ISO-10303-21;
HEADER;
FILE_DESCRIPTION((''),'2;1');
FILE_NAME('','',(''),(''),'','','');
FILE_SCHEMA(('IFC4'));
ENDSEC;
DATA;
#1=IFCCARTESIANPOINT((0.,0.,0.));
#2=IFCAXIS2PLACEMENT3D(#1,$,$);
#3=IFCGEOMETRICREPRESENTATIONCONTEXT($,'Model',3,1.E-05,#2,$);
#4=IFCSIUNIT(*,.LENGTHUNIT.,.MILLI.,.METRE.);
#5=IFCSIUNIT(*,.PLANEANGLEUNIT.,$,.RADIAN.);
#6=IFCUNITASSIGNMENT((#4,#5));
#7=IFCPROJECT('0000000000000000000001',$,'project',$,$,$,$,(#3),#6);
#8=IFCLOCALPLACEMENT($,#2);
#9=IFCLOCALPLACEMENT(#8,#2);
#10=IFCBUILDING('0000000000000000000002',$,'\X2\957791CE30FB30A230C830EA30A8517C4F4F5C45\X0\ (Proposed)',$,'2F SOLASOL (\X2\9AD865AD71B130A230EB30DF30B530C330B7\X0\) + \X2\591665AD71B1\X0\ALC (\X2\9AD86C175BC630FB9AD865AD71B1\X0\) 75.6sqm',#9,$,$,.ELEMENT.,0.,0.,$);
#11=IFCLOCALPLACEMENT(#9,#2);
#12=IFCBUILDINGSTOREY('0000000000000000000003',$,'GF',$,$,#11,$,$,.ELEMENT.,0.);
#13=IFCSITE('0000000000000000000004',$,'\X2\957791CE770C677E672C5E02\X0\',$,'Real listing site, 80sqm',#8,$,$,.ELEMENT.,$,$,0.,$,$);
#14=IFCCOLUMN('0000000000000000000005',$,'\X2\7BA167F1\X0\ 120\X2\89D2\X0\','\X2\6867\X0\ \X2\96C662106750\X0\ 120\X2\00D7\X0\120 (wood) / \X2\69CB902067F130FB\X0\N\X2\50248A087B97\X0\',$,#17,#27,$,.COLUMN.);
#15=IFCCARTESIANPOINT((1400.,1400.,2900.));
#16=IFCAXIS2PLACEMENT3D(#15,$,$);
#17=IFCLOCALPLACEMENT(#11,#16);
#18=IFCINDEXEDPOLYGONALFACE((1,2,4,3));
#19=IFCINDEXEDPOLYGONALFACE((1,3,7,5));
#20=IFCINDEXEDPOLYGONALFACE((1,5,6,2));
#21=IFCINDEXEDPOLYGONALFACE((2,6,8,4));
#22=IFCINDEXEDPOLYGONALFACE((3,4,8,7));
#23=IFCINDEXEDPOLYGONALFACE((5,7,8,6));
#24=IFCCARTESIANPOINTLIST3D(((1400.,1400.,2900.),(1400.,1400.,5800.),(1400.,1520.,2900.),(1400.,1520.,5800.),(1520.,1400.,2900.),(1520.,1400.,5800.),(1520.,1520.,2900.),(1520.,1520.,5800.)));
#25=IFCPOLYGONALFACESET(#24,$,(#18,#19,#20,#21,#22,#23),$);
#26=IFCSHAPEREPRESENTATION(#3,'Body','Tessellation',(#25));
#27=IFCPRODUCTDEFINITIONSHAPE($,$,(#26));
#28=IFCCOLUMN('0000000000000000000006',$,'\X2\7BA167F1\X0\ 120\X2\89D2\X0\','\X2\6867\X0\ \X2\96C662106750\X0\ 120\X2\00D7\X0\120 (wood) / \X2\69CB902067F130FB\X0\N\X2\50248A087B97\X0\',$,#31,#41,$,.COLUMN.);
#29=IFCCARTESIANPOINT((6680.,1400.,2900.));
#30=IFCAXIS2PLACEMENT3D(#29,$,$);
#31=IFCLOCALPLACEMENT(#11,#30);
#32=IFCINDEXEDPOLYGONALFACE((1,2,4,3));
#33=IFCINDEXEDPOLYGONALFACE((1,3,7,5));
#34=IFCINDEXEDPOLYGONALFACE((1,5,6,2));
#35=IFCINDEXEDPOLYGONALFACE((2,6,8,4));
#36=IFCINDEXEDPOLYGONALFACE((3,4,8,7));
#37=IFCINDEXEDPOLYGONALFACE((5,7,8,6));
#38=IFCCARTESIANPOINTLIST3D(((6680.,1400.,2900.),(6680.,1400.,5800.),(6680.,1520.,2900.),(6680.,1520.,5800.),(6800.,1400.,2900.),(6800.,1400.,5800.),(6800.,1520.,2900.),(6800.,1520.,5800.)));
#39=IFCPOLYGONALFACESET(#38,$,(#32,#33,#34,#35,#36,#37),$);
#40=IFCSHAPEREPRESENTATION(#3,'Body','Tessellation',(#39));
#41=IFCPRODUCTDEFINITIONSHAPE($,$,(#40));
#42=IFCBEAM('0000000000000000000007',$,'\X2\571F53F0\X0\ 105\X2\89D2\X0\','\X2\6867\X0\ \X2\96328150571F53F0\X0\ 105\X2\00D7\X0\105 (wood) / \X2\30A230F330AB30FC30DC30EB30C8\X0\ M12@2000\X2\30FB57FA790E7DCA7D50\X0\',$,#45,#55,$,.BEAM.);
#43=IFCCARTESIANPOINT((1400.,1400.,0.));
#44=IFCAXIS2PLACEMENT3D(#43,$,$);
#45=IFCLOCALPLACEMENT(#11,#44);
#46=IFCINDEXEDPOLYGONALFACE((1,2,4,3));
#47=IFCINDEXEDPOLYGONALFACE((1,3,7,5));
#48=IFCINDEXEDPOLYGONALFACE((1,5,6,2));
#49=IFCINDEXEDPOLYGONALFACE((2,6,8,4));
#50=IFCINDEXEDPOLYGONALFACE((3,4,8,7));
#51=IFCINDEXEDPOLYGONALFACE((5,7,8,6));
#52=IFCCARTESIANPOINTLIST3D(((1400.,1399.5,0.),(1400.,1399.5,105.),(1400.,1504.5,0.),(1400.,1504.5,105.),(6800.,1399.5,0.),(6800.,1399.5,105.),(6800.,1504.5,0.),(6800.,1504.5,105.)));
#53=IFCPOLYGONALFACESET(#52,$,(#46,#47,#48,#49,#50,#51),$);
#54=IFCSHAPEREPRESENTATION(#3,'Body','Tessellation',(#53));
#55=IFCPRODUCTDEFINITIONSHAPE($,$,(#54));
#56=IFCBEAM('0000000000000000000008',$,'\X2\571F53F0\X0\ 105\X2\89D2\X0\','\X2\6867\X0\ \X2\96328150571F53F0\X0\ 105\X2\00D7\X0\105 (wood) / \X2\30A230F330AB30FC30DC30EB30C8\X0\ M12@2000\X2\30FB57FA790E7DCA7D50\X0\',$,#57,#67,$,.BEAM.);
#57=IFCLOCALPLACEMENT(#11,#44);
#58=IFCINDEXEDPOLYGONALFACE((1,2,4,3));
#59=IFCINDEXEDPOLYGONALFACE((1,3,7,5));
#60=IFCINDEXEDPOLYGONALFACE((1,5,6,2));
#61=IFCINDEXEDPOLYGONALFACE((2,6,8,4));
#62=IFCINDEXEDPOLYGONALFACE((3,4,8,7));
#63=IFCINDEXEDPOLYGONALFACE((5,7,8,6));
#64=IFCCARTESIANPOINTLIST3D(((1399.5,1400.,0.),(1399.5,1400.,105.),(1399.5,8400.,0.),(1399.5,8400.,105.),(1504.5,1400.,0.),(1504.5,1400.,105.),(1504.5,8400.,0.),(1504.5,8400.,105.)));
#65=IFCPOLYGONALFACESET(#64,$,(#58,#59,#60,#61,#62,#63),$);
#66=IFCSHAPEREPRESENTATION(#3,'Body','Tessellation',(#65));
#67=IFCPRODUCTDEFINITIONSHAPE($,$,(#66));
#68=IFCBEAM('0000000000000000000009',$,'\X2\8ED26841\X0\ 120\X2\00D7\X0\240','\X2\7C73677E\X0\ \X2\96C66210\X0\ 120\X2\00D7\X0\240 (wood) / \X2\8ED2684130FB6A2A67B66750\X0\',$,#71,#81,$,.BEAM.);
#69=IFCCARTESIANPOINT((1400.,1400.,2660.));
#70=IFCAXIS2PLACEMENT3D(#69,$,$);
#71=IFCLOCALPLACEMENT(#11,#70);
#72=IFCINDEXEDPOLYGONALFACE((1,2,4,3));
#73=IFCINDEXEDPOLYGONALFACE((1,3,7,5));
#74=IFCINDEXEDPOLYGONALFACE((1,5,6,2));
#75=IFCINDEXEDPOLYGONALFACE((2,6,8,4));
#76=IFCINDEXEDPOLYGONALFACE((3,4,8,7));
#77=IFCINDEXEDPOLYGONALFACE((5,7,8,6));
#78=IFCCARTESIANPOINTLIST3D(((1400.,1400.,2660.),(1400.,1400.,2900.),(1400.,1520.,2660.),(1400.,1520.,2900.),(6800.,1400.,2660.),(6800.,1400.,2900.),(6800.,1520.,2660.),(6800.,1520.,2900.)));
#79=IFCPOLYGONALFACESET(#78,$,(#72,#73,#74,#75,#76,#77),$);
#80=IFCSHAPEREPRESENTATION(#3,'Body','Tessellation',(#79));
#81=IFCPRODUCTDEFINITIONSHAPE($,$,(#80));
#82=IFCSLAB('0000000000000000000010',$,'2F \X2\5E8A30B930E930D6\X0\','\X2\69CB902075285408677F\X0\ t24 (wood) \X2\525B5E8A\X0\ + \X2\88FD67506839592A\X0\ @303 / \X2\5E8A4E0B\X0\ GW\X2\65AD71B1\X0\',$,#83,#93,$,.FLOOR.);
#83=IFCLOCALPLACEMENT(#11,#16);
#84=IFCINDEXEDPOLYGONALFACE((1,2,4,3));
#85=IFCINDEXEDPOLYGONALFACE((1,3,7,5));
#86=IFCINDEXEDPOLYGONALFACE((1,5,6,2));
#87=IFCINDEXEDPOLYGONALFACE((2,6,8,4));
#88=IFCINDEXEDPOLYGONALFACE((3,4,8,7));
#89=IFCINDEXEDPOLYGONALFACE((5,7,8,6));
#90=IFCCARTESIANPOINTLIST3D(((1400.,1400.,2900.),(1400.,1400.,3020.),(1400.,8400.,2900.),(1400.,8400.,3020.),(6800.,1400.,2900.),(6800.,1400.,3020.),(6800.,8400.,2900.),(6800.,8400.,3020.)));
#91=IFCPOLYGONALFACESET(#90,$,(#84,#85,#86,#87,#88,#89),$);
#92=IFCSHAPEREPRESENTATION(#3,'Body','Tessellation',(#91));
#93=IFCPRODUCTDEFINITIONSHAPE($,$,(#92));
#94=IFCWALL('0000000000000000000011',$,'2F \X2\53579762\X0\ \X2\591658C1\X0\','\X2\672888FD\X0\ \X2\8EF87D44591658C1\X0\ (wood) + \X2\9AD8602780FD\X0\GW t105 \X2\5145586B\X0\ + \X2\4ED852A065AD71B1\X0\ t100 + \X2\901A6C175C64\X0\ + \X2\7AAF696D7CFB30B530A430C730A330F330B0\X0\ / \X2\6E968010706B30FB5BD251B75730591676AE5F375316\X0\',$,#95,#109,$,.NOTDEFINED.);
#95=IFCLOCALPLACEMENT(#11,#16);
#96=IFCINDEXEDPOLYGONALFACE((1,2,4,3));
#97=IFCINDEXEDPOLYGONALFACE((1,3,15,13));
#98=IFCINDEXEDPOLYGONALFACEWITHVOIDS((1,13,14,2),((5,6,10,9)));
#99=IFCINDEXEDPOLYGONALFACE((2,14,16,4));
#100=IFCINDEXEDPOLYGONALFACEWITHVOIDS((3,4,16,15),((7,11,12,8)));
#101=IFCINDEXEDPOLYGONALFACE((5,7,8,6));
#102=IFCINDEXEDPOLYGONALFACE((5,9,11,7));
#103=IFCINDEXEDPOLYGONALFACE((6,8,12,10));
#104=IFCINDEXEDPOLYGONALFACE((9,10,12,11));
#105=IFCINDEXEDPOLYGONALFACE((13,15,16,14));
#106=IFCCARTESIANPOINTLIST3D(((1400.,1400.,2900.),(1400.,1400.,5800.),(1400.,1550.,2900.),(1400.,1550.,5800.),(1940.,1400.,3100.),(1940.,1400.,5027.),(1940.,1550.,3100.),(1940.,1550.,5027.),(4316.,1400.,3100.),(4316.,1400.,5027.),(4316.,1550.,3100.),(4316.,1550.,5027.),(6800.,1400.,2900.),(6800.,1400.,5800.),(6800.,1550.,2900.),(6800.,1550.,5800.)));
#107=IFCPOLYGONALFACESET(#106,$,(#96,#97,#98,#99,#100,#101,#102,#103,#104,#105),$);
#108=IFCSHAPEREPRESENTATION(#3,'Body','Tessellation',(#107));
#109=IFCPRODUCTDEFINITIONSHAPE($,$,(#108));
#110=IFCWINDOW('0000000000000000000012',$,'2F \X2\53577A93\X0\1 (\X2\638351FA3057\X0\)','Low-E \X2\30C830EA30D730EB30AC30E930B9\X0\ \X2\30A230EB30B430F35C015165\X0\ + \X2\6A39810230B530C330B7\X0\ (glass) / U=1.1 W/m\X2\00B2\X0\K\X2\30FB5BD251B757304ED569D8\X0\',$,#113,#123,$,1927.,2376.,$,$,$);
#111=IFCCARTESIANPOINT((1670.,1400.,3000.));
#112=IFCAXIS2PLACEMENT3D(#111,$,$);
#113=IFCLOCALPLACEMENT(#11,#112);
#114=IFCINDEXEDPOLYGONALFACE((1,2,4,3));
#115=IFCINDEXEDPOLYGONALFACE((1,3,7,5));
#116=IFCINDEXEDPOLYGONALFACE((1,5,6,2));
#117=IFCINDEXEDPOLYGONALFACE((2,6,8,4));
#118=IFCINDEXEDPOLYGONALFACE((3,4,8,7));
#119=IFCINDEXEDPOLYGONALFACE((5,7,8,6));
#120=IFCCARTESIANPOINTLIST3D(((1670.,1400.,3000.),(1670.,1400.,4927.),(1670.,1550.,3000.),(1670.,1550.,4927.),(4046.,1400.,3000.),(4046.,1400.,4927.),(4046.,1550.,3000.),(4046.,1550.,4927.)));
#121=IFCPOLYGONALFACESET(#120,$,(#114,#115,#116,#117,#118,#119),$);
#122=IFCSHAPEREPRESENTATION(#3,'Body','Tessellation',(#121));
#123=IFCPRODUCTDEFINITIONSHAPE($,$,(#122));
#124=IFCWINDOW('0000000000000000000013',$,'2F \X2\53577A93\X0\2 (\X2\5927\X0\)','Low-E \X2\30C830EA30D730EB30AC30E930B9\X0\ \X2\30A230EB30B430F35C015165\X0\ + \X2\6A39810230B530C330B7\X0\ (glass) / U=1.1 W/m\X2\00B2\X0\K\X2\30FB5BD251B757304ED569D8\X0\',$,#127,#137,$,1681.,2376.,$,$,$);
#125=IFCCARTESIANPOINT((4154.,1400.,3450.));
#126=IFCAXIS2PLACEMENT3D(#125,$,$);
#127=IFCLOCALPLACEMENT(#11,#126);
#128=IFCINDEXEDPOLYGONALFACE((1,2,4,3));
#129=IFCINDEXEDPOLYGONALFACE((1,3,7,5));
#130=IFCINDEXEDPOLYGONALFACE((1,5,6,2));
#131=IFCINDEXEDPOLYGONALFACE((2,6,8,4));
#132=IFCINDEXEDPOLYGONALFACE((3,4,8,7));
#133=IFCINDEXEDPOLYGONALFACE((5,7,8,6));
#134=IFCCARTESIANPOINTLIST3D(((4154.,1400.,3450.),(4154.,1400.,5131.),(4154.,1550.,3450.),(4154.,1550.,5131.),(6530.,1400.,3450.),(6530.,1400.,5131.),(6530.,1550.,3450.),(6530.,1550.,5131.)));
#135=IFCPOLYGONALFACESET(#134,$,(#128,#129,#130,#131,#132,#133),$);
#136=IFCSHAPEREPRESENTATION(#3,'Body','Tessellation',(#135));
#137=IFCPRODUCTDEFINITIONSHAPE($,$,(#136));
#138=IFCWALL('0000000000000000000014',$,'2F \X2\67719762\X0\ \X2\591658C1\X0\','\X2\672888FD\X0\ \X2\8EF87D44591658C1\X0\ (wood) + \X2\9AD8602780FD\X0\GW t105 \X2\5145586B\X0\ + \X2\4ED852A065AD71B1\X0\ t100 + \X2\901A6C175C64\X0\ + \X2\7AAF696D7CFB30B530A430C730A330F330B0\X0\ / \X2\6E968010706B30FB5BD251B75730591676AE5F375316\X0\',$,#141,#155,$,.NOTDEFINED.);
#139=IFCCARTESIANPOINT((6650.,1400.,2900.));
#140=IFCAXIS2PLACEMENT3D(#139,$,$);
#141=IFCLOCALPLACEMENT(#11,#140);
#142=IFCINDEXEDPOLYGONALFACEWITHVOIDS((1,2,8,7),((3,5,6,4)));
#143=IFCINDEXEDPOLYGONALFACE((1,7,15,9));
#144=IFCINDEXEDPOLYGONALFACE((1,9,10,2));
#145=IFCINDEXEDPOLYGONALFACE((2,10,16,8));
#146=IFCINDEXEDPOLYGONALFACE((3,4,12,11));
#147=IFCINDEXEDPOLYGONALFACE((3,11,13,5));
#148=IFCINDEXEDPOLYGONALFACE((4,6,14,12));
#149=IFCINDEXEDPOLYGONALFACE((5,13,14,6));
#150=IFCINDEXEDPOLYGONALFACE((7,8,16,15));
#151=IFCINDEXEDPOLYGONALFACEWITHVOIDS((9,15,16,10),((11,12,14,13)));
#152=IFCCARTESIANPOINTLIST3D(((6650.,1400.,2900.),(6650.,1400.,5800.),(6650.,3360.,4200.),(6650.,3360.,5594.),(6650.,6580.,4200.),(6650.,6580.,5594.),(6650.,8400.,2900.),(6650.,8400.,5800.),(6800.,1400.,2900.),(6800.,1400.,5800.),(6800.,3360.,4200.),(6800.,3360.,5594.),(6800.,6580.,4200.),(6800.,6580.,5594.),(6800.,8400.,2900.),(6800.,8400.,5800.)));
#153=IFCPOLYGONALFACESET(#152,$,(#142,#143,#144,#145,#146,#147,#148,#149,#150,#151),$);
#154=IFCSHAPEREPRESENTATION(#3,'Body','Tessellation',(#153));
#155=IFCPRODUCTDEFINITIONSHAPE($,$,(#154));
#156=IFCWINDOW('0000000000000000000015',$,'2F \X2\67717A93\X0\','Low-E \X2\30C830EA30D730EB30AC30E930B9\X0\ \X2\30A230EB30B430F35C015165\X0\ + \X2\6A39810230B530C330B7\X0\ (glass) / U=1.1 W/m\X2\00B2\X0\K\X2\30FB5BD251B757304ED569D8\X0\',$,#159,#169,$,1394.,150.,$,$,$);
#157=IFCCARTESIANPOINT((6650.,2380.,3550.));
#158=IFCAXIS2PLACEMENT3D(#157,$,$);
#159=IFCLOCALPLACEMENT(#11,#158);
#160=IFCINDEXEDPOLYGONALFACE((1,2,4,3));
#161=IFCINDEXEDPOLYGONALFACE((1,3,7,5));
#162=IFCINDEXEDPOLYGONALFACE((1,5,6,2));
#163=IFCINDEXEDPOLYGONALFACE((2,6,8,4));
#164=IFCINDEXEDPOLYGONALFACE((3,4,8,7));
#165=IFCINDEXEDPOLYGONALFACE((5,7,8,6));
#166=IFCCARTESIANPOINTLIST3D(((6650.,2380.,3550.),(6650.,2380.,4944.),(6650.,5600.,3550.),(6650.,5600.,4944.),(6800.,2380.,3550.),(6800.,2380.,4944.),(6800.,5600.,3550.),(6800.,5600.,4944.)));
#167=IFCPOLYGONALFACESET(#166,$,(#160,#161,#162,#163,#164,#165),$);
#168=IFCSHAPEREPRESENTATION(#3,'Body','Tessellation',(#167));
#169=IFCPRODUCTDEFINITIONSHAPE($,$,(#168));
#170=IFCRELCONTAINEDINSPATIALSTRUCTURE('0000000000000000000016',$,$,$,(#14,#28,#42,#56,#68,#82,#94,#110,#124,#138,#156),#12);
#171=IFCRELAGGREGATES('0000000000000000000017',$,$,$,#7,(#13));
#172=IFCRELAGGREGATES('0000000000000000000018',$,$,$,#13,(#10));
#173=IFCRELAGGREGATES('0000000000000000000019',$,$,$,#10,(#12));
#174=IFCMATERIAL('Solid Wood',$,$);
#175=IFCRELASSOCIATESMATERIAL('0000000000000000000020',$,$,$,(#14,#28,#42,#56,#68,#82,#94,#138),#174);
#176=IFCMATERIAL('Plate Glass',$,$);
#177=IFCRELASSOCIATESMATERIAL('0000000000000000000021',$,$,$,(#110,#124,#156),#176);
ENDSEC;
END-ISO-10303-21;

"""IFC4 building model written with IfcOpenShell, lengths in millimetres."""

from ifc_helpers import new_model, si_unit, frame, frame_2d, origin, place, context, project, spatial, rectangle, extrude, material, element, fill, save


model = new_model("IFC4")

# Units and contexts
model_context = context("Model", 3, precision=1e-05, world=origin())
ifc_project = project(units=[si_unit("LENGTHUNIT", "METRE", prefix="MILLI"), si_unit("PLANEANGLEUNIT", "RADIAN")], contexts=[model_context])

# Site, building, storey
site_placement = place(None, origin())
site = spatial("IfcSite", under=ifc_project, at=site_placement, Name="長野県松本市", ObjectType="Real listing site, 80sqm", CompositionType="ELEMENT", RefElevation=0.0)
building_placement = place(site_placement, origin())
building = spatial("IfcBuilding", under=site, at=building_placement, Name="長野・アトリエ兼住居 (Proposed)", ObjectType="2F SOLASOL (高断熱アルミサッシ) + 外断熱ALC (高気密・高断熱) 75.6sqm", CompositionType="ELEMENT", ElevationOfRefHeight=0.0, ElevationOfTerrain=0.0)
storey_placement = place(building_placement, origin())
storey = spatial("IfcBuildingStorey", under=building, at=storey_placement, Name="GF", CompositionType="ELEMENT", Elevation=0.0)

# Columns
ifc_material_1 = material(Name="Solid Wood")
column_1_placement = place(storey_placement, frame((1400.0, 1400.0, 2900.0)))
element("IfcColumn", 1, at=column_1_placement, inside=storey, material=ifc_material_1, Name="管柱 120角", Description="桧 集成材 120×120 (wood) / 構造柱・N値計算", PredefinedType="COLUMN", context=model_context, shape_type="SweptSolid", body=[
    extrude(rectangle(XDim=120.0, YDim=120.0, at=frame_2d((60.0, 60.0))), frame((1400.0, 1400.0, 2900.0)), (0.0, 0.0, 1.0), 2900.0),
])
column_2_placement = place(storey_placement, frame((6680.0, 1400.0, 2900.0)))
element("IfcColumn", 2, at=column_2_placement, inside=storey, material=ifc_material_1, Name="管柱 120角", Description="桧 集成材 120×120 (wood) / 構造柱・N値計算", PredefinedType="COLUMN", context=model_context, shape_type="SweptSolid", body=[
    extrude(rectangle(XDim=120.0, YDim=120.0, at=frame_2d((60.0, 60.0))), frame((6680.0, 1400.0, 2900.0)), (0.0, 0.0, 1.0), 2900.0),
])

# Beams
beam_1_placement = place(storey_placement, frame((1400.0, 1400.0, 0.0)))
element("IfcBeam", 3, at=beam_1_placement, inside=storey, material=ifc_material_1, Name="土台 105角", Description="桧 防腐土台 105×105 (wood) / アンカーボルト M12@2000・基礎緊結", PredefinedType="BEAM", context=model_context, shape_type="SweptSolid", body=[
    extrude(rectangle(XDim=5400.0, YDim=105.0, at=frame_2d((2700.0, 52.0))), frame((1400.0, 1400.0, 0.0)), (0.0, 0.0, 1.0), 105.0),
])
beam_2_placement = place(storey_placement, frame((1400.0, 1400.0, 0.0)))
element("IfcBeam", 4, at=beam_2_placement, inside=storey, material=ifc_material_1, Name="土台 105角", Description="桧 防腐土台 105×105 (wood) / アンカーボルト M12@2000・基礎緊結", PredefinedType="BEAM", context=model_context, shape_type="SweptSolid", body=[
    extrude(rectangle(XDim=105.0, YDim=7000.0, at=frame_2d((52.0, 3500.0))), frame((1400.0, 1400.0, 0.0)), (0.0, 0.0, 1.0), 105.0),
])
beam_3_placement = place(storey_placement, frame((1400.0, 1400.0, 2660.0)))
element("IfcBeam", 5, at=beam_3_placement, inside=storey, material=ifc_material_1, Name="軒桁 120×240", Description="米松 集成 120×240 (wood) / 軒桁・横架材", PredefinedType="BEAM", context=model_context, shape_type="SweptSolid", body=[
    extrude(rectangle(XDim=5400.0, YDim=120.0, at=frame_2d((2700.0, 60.0))), frame((1400.0, 1400.0, 2660.0)), (0.0, 0.0, 1.0), 240.0),
])

# Slab
slab_placement = place(storey_placement, frame((1400.0, 1400.0, 2900.0)))
element("IfcSlab", 6, at=slab_placement, inside=storey, material=ifc_material_1, Name="2F 床スラブ", Description="構造用合板 t24 (wood) 剛床 + 製材根太 @303 / 床下 GW断熱", PredefinedType="FLOOR", context=model_context, shape_type="SweptSolid", body=[
    extrude(rectangle(XDim=5400.0, YDim=7000.0, at=frame_2d((2700.0, 3500.0))), frame((1400.0, 1400.0, 2900.0)), (0.0, 0.0, 1.0), 120.0),
])

# Wall, openings, windows
wall_1_placement = place(storey_placement, frame((1400.0, 1400.0, 2900.0)))
wall_1 = element("IfcWall", 7, at=wall_1_placement, inside=storey, material=ifc_material_1, Name="2F 南面 外壁", Description="木製 軸組外壁 (wood) + 高性能GW t105 充填 + 付加断熱 t100 + 通気層 + 窯業系サイディング / 準耐火・寒冷地外皮強化", PredefinedType="NOTDEFINED", context=model_context, shape_type="SweptSolid", body=[
    extrude(rectangle(XDim=5400.0, YDim=150.0, at=frame_2d((2700.0, 75.0))), frame((1400.0, 1400.0, 2900.0)), (0.0, 0.0, 1.0), 2900.0),
])
opening_1_placement = place(storey_placement, frame((1670.0, 1400.0, 3000.0)))
opening_1 = element("IfcOpeningElement", 8, at=opening_1_placement, cuts=wall_1, PredefinedType="NOTDEFINED", context=model_context, shape_type="SweptSolid", body=[
    extrude(rectangle(XDim=2376.0, YDim=150.0, at=frame_2d((1188.0, 75.0))), frame((1670.0, 1400.0, 3000.0)), (0.0, 0.0, 1.0), 1927.0),
])
opening_2_placement = place(storey_placement, frame((4154.0, 1400.0, 3450.0)))
opening_2 = element("IfcOpeningElement", 9, at=opening_2_placement, cuts=wall_1, PredefinedType="NOTDEFINED", context=model_context, shape_type="SweptSolid", body=[
    extrude(rectangle(XDim=2376.0, YDim=150.0, at=frame_2d((1188.0, 75.0))), frame((4154.0, 1400.0, 3450.0)), (0.0, 0.0, 1.0), 1681.0),
])
ifc_material_2 = material(Name="Plate Glass")
window_1_placement = place(storey_placement, frame((1670.0, 1400.0, 3000.0)))
window_1 = element("IfcWindow", 10, at=window_1_placement, inside=storey, material=ifc_material_2, Name="2F 南窓1 (掃出し)", Description="Low-E トリプルガラス アルゴン封入 + 樹脂サッシ (glass) / U=1.1 W/m²K・寒冷地仕様", OverallHeight=1927.0, OverallWidth=2376.0, context=model_context, shape_type="SweptSolid", body=[
    extrude(rectangle(XDim=2376.0, YDim=150.0, at=frame_2d((1188.0, 75.0))), frame((1670.0, 1400.0, 3000.0)), (0.0, 0.0, 1.0), 1927.0),
])
fill(opening_1, window_1)
window_2_placement = place(storey_placement, frame((4154.0, 1400.0, 3450.0)))
window_2 = element("IfcWindow", 11, at=window_2_placement, inside=storey, material=ifc_material_2, Name="2F 南窓2 (大)", Description="Low-E トリプルガラス アルゴン封入 + 樹脂サッシ (glass) / U=1.1 W/m²K・寒冷地仕様", OverallHeight=1681.0, OverallWidth=2376.0, context=model_context, shape_type="SweptSolid", body=[
    extrude(rectangle(XDim=2376.0, YDim=150.0, at=frame_2d((1188.0, 75.0))), frame((4154.0, 1400.0, 3450.0)), (0.0, 0.0, 1.0), 1681.0),
])
fill(opening_2, window_2)

# Wall, opening, window
wall_2_placement = place(storey_placement, frame((6650.0, 1400.0, 2900.0)))
wall_2 = element("IfcWall", 12, at=wall_2_placement, inside=storey, material=ifc_material_1, Name="2F 東面 外壁", Description="木製 軸組外壁 (wood) + 高性能GW t105 充填 + 付加断熱 t100 + 通気層 + 窯業系サイディング / 準耐火・寒冷地外皮強化", PredefinedType="NOTDEFINED", context=model_context, shape_type="SweptSolid", body=[
    extrude(rectangle(XDim=150.0, YDim=7000.0, at=frame_2d((75.0, 3500.0))), frame((6650.0, 1400.0, 2900.0)), (0.0, 0.0, 1.0), 2900.0),
])
opening_3_placement = place(storey_placement, frame((6650.0, 2380.0, 3550.0)))
opening_3 = element("IfcOpeningElement", 13, at=opening_3_placement, cuts=wall_2, PredefinedType="NOTDEFINED", context=model_context, shape_type="SweptSolid", body=[
    extrude(rectangle(XDim=150.0, YDim=3220.0, at=frame_2d((75.0, 1610.0))), frame((6650.0, 2380.0, 3550.0)), (0.0, 0.0, 1.0), 1394.0),
])
window_3_placement = place(storey_placement, frame((6650.0, 2380.0, 3550.0)))
window_3 = element("IfcWindow", 14, at=window_3_placement, inside=storey, material=ifc_material_2, Name="2F 東窓", Description="Low-E トリプルガラス アルゴン封入 + 樹脂サッシ (glass) / U=1.1 W/m²K・寒冷地仕様", OverallHeight=1394.0, OverallWidth=150.0, context=model_context, shape_type="SweptSolid", body=[
    extrude(rectangle(XDim=150.0, YDim=3220.0, at=frame_2d((75.0, 1610.0))), frame((6650.0, 2380.0, 3550.0)), (0.0, 0.0, 1.0), 1394.0),
])
fill(opening_3, window_3)

save(model, "model.ifc")
